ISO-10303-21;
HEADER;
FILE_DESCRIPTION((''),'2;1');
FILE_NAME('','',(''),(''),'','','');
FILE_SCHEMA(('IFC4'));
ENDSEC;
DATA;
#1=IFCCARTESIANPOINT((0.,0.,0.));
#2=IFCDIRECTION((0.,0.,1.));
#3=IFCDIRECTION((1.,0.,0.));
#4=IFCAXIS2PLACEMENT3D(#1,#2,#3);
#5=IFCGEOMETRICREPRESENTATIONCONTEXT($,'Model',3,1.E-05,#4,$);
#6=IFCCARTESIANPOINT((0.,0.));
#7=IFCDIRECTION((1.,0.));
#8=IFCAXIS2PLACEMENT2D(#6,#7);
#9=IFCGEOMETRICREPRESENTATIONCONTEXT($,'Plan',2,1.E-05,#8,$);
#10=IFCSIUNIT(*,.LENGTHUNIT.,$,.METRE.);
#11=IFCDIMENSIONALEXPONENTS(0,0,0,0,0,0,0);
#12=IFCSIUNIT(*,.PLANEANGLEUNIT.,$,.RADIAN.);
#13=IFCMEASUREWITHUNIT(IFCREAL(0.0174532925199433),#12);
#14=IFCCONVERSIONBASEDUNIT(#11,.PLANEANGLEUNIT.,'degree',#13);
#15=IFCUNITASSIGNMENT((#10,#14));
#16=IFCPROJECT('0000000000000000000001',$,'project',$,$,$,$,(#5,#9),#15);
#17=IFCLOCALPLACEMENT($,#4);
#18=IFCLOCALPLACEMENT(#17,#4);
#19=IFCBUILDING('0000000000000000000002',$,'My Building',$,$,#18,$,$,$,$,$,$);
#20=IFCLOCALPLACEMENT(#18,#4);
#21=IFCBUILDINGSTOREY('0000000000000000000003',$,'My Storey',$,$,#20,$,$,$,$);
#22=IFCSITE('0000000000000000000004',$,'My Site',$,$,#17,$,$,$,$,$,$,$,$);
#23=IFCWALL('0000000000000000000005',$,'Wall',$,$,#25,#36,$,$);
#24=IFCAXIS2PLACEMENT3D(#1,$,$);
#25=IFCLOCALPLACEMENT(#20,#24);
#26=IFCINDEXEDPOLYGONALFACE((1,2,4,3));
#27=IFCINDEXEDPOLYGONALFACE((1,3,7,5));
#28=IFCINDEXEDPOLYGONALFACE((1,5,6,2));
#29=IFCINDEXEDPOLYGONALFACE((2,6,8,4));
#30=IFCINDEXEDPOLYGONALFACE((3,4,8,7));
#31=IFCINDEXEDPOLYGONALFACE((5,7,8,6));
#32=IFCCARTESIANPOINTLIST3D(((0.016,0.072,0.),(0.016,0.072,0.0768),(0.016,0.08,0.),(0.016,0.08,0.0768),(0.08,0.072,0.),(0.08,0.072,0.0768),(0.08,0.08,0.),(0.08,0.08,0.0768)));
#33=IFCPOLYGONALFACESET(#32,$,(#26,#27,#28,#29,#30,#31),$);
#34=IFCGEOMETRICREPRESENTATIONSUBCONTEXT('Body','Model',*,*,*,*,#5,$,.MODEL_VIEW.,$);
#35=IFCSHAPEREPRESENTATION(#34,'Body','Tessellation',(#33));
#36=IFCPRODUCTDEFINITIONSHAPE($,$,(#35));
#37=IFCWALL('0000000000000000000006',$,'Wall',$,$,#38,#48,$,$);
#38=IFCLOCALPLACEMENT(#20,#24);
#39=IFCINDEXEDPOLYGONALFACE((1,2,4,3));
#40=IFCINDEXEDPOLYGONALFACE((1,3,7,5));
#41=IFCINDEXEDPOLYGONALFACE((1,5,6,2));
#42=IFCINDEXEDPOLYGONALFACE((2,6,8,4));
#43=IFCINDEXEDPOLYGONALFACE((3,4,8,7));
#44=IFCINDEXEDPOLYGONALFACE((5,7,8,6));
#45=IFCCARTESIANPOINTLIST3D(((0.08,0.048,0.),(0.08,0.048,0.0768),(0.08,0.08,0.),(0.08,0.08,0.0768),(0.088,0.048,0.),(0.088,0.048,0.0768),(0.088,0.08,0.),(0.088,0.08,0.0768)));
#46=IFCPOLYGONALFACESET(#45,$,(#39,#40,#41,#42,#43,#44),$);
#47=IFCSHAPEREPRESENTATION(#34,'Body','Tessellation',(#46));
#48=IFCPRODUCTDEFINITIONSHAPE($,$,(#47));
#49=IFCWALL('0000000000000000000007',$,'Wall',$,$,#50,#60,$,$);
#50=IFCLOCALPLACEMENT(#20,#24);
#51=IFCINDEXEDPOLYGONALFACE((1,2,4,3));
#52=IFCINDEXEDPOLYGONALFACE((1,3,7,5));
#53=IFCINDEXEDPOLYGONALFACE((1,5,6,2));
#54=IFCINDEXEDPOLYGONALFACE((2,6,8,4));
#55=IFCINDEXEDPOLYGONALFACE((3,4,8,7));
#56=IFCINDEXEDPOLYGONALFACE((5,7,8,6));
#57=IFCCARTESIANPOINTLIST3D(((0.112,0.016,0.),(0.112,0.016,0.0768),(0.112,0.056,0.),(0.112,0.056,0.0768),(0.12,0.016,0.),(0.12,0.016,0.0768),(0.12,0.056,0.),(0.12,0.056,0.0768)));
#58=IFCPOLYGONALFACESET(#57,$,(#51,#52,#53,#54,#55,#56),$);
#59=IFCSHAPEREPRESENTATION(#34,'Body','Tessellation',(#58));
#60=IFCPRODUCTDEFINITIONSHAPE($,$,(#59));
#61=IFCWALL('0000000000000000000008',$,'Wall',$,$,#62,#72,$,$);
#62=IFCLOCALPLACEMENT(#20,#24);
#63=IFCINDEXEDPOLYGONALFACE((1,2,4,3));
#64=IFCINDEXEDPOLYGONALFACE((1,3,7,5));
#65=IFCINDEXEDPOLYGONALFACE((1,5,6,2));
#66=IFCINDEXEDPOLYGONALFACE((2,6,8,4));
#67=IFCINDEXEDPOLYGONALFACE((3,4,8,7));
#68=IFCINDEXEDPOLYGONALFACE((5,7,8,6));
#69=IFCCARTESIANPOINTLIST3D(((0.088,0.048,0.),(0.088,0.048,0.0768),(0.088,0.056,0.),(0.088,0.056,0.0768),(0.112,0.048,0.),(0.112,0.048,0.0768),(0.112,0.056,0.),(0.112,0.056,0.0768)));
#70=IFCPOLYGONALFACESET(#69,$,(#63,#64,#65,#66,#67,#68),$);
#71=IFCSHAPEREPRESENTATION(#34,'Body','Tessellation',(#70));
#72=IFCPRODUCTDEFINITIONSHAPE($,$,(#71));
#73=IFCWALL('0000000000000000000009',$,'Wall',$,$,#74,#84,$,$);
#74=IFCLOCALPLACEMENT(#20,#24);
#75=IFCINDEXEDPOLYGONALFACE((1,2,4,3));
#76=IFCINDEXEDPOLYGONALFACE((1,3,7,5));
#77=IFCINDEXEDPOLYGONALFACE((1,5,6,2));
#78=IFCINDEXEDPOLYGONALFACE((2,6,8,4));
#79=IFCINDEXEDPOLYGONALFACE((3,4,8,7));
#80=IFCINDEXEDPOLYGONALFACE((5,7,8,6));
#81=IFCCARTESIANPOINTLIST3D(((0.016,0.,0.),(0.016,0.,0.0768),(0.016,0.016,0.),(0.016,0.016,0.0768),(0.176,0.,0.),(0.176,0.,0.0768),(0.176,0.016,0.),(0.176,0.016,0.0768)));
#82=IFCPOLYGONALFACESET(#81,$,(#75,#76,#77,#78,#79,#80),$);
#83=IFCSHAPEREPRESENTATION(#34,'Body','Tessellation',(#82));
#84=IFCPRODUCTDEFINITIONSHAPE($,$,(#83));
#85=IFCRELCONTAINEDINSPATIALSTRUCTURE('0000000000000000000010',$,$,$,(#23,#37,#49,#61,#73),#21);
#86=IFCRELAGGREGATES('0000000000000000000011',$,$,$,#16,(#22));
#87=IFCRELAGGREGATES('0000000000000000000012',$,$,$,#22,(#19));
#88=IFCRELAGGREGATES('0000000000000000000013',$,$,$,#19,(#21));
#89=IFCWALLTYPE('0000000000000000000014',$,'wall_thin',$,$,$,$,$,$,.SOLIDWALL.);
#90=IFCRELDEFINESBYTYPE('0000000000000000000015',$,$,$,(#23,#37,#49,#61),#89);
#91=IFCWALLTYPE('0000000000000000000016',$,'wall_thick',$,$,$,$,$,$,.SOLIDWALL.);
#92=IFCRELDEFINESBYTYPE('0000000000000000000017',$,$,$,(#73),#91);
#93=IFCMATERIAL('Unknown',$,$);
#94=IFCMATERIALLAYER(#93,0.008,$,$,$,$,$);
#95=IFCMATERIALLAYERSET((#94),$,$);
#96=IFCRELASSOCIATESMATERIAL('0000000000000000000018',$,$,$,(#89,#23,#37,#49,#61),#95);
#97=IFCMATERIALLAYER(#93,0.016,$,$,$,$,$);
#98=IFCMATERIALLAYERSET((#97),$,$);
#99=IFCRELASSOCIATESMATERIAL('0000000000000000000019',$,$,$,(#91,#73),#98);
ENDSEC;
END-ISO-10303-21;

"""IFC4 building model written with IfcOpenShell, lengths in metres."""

from ifc_helpers import new_model, entity, si_unit, converted_unit, frame, origin_with_axes, origin_2d_with_axis, place, context, subcontext, project, spatial, indexed_curve, outline, extrude, material, layer, layer_set, layer_usage, type_object, element, save


model = new_model("IFC4")

# Units and contexts
model_context = context("Model", 3, precision=1e-05, world=origin_with_axes())
plan_context = context("Plan", 2, precision=1e-05, world=origin_2d_with_axis())
body_context_1 = subcontext(model_context, "Body", "Model", "MODEL_VIEW")
ifc_project = project(units=[si_unit("LENGTHUNIT", "METRE"), converted_unit("PLANEANGLEUNIT", "degree", entity("IfcReal", 0.0174532925199433), si_unit("PLANEANGLEUNIT", "RADIAN"), dimensions=[0, 0, 0, 0, 0, 0, 0])], contexts=[model_context, plan_context])

# Site, building, storey
site_placement = place(None, origin_with_axes())
site = spatial("IfcSite", under=ifc_project, at=site_placement, Name="My Site")
building_placement = place(site_placement, origin_with_axes())
building = spatial("IfcBuilding", under=site, at=building_placement, Name="My Building")
storey_placement = place(building_placement, origin_with_axes())
storey = spatial("IfcBuildingStorey", under=building, at=storey_placement, Name="My Storey")

# Walls
ifc_material = material(Name="Unknown")
ifc_layer_1 = layer(ifc_material, 0.008)
ifc_layer_set_1 = layer_set([ifc_layer_1])
ifc_layer_usage_1 = layer_usage(ifc_layer_set_1, "AXIS2", "POSITIVE", 0.0)
wall_type_1 = type_object("IfcWallType", Name="wall_thin", PredefinedType="SOLIDWALL", material=ifc_layer_set_1)
wall_1_placement = place(storey_placement, frame((0.016, 0.072, 0.0), z_axis=(0.0, 0.0, 1.0), x_axis=(1.0, 0.0, 0.0)))
element("IfcWall", 1, at=wall_1_placement, inside=storey, type_object=wall_type_1, material=ifc_layer_usage_1, Name="Wall", context=body_context_1, shape_type="SweptSolid", body=[
    extrude(outline(indexed_curve([(0.0, 0.0), (0.0, 0.008), (0.064, 0.008), (0.064, 0.0), (0.0, 0.0)], self_intersect=False)), origin_with_axes(), (0.0, 0.0, 1.0), 0.0768),
])
ifc_layer_usage_2 = layer_usage(ifc_layer_set_1, "AXIS2", "POSITIVE", 0.0)
wall_2_placement = place(storey_placement, frame((0.088, 0.048, 0.0), z_axis=(0.0, 0.0, 1.0), x_axis=(0.0, 1.0, 0.0)))
element("IfcWall", 2, at=wall_2_placement, inside=storey, type_object=wall_type_1, material=ifc_layer_usage_2, Name="Wall", context=body_context_1, shape_type="SweptSolid", body=[
    extrude(outline(indexed_curve([(0.0, 0.0), (0.0, 0.008), (0.032, 0.008), (0.032, 0.0), (0.0, 0.0)], self_intersect=False)), origin_with_axes(), (0.0, 0.0, 1.0), 0.0768),
])
ifc_layer_usage_3 = layer_usage(ifc_layer_set_1, "AXIS2", "POSITIVE", 0.0)
wall_3_placement = place(storey_placement, frame((0.12, 0.016, 0.0), z_axis=(0.0, 0.0, 1.0), x_axis=(0.0, 1.0, 0.0)))
element("IfcWall", 3, at=wall_3_placement, inside=storey, type_object=wall_type_1, material=ifc_layer_usage_3, Name="Wall", context=body_context_1, shape_type="SweptSolid", body=[
    extrude(outline(indexed_curve([(0.0, 0.0), (0.0, 0.008), (0.04, 0.008), (0.04, 0.0), (0.0, 0.0)], self_intersect=False)), origin_with_axes(), (0.0, 0.0, 1.0), 0.0768),
])
ifc_layer_usage_4 = layer_usage(ifc_layer_set_1, "AXIS2", "POSITIVE", 0.0)
wall_4_placement = place(storey_placement, frame((0.088, 0.048, 0.0), z_axis=(0.0, 0.0, 1.0), x_axis=(1.0, 0.0, 0.0)))
element("IfcWall", 4, at=wall_4_placement, inside=storey, type_object=wall_type_1, material=ifc_layer_usage_4, Name="Wall", context=body_context_1, shape_type="SweptSolid", body=[
    extrude(outline(indexed_curve([(0.0, 0.0), (0.0, 0.008), (0.024, 0.008), (0.024, 0.0), (0.0, 0.0)], self_intersect=False)), origin_with_axes(), (0.0, 0.0, 1.0), 0.0768),
])
ifc_layer_2 = layer(ifc_material, 0.016)
ifc_layer_set_2 = layer_set([ifc_layer_2])
ifc_layer_usage_5 = layer_usage(ifc_layer_set_2, "AXIS2", "POSITIVE", 0.0)
wall_type_2 = type_object("IfcWallType", Name="wall_thick", PredefinedType="SOLIDWALL", material=ifc_layer_set_2)
wall_5_placement = place(storey_placement, frame((0.016, 0.0, 0.0), z_axis=(0.0, 0.0, 1.0), x_axis=(1.0, 0.0, 0.0)))
element("IfcWall", 5, at=wall_5_placement, inside=storey, type_object=wall_type_2, material=ifc_layer_usage_5, Name="Wall", context=body_context_1, shape_type="SweptSolid", body=[
    extrude(outline(indexed_curve([(0.0, 0.0), (0.0, 0.016), (0.16, 0.016), (0.16, 0.0), (0.0, 0.0)], self_intersect=False)), origin_with_axes(), (0.0, 0.0, 1.0), 0.0768),
])

save(model, "model.ifc")
